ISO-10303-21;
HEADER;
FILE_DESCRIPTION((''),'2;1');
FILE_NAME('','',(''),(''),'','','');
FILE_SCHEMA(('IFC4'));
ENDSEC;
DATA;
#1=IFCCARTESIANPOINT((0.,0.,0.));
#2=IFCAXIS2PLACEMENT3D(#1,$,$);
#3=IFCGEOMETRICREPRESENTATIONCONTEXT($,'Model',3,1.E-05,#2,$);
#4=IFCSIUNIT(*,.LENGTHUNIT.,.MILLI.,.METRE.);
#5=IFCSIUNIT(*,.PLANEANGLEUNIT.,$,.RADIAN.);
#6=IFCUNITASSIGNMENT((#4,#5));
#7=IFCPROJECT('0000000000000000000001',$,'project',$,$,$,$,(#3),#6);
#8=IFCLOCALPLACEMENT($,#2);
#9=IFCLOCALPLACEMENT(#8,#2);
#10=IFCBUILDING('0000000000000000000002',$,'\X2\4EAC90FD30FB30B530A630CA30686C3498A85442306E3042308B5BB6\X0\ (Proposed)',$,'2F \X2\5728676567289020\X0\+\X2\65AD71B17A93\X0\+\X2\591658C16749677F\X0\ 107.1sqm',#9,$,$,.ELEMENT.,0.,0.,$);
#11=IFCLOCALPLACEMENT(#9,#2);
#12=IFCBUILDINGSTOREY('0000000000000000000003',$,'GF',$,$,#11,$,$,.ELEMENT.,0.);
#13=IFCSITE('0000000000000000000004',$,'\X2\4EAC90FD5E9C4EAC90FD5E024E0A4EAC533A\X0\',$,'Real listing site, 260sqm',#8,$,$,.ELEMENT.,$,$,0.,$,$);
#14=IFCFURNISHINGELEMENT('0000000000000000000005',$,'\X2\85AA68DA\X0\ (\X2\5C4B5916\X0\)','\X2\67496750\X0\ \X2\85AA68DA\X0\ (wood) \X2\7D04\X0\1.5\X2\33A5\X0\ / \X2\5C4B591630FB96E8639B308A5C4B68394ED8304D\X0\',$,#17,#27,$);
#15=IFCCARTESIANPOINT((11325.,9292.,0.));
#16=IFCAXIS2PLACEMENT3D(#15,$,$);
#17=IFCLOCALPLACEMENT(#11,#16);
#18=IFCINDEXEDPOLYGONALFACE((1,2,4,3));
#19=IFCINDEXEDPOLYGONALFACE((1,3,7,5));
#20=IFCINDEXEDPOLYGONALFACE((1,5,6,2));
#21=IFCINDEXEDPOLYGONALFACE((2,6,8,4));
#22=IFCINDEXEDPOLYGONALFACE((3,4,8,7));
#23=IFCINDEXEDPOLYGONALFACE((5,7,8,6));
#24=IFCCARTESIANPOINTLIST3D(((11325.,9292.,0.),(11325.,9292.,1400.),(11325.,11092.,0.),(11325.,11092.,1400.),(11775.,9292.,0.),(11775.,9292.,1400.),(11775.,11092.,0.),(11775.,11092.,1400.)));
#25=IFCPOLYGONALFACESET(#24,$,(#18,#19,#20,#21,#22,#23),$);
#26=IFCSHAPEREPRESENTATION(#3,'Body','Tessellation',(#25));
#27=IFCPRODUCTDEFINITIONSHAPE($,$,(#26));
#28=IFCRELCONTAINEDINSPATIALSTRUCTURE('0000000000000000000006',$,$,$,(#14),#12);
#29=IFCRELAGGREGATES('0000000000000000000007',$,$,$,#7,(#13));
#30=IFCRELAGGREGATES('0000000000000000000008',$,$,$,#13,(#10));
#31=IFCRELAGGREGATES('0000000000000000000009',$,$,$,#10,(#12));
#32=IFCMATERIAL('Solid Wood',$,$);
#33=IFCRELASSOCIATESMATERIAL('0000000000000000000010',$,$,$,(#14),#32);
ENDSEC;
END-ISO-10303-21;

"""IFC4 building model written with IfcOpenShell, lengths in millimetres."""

from ifc_helpers import new_model, si_unit, frame, frame_2d, origin, place, context, project, spatial, rectangle, extrude, material, element, save


model = new_model("IFC4")

# Units and contexts
model_context = context("Model", 3, precision=1e-05, world=origin())
ifc_project = project(units=[si_unit("LENGTHUNIT", "METRE", prefix="MILLI"), si_unit("PLANEANGLEUNIT", "RADIAN")], contexts=[model_context])

# Site, building, storey
site_placement = place(None, origin())
site = spatial("IfcSite", under=ifc_project, at=site_placement, Name="京都府京都市上京区", ObjectType="Real listing site, 260sqm", CompositionType="ELEMENT", RefElevation=0.0)
building_placement = place(site_placement, origin())
building = spatial("IfcBuilding", under=site, at=building_placement, Name="京都・サウナと水風呂のある家 (Proposed)", ObjectType="2F 在来木造+断熱窓+外壁杉板 107.1sqm", CompositionType="ELEMENT", ElevationOfRefHeight=0.0, ElevationOfTerrain=0.0)
storey_placement = place(building_placement, origin())
storey = spatial("IfcBuildingStorey", under=building, at=storey_placement, Name="GF", CompositionType="ELEMENT", Elevation=0.0)

# Shared definitions
ifc_material_1 = material(Name="Solid Wood")

# Furnishing element
furnishing_placement = place(storey_placement, frame((11325.0, 9292.0, 0.0)))
element("IfcFurnishingElement", 1, at=furnishing_placement, inside=storey, material=ifc_material_1, Name="薪棚 (屋外)", Description="杉材 薪棚 (wood) 約1.5㎥ / 屋外・雨掛り屋根付き", context=model_context, shape_type="SweptSolid", body=[
    extrude(rectangle(XDim=450.0, YDim=1800.0, at=frame_2d((225.0, 900.0))), frame((11325.0, 9292.0, 0.0)), (0.0, 0.0, 1.0), 1400.0),
])

save(model, "model.ifc")
